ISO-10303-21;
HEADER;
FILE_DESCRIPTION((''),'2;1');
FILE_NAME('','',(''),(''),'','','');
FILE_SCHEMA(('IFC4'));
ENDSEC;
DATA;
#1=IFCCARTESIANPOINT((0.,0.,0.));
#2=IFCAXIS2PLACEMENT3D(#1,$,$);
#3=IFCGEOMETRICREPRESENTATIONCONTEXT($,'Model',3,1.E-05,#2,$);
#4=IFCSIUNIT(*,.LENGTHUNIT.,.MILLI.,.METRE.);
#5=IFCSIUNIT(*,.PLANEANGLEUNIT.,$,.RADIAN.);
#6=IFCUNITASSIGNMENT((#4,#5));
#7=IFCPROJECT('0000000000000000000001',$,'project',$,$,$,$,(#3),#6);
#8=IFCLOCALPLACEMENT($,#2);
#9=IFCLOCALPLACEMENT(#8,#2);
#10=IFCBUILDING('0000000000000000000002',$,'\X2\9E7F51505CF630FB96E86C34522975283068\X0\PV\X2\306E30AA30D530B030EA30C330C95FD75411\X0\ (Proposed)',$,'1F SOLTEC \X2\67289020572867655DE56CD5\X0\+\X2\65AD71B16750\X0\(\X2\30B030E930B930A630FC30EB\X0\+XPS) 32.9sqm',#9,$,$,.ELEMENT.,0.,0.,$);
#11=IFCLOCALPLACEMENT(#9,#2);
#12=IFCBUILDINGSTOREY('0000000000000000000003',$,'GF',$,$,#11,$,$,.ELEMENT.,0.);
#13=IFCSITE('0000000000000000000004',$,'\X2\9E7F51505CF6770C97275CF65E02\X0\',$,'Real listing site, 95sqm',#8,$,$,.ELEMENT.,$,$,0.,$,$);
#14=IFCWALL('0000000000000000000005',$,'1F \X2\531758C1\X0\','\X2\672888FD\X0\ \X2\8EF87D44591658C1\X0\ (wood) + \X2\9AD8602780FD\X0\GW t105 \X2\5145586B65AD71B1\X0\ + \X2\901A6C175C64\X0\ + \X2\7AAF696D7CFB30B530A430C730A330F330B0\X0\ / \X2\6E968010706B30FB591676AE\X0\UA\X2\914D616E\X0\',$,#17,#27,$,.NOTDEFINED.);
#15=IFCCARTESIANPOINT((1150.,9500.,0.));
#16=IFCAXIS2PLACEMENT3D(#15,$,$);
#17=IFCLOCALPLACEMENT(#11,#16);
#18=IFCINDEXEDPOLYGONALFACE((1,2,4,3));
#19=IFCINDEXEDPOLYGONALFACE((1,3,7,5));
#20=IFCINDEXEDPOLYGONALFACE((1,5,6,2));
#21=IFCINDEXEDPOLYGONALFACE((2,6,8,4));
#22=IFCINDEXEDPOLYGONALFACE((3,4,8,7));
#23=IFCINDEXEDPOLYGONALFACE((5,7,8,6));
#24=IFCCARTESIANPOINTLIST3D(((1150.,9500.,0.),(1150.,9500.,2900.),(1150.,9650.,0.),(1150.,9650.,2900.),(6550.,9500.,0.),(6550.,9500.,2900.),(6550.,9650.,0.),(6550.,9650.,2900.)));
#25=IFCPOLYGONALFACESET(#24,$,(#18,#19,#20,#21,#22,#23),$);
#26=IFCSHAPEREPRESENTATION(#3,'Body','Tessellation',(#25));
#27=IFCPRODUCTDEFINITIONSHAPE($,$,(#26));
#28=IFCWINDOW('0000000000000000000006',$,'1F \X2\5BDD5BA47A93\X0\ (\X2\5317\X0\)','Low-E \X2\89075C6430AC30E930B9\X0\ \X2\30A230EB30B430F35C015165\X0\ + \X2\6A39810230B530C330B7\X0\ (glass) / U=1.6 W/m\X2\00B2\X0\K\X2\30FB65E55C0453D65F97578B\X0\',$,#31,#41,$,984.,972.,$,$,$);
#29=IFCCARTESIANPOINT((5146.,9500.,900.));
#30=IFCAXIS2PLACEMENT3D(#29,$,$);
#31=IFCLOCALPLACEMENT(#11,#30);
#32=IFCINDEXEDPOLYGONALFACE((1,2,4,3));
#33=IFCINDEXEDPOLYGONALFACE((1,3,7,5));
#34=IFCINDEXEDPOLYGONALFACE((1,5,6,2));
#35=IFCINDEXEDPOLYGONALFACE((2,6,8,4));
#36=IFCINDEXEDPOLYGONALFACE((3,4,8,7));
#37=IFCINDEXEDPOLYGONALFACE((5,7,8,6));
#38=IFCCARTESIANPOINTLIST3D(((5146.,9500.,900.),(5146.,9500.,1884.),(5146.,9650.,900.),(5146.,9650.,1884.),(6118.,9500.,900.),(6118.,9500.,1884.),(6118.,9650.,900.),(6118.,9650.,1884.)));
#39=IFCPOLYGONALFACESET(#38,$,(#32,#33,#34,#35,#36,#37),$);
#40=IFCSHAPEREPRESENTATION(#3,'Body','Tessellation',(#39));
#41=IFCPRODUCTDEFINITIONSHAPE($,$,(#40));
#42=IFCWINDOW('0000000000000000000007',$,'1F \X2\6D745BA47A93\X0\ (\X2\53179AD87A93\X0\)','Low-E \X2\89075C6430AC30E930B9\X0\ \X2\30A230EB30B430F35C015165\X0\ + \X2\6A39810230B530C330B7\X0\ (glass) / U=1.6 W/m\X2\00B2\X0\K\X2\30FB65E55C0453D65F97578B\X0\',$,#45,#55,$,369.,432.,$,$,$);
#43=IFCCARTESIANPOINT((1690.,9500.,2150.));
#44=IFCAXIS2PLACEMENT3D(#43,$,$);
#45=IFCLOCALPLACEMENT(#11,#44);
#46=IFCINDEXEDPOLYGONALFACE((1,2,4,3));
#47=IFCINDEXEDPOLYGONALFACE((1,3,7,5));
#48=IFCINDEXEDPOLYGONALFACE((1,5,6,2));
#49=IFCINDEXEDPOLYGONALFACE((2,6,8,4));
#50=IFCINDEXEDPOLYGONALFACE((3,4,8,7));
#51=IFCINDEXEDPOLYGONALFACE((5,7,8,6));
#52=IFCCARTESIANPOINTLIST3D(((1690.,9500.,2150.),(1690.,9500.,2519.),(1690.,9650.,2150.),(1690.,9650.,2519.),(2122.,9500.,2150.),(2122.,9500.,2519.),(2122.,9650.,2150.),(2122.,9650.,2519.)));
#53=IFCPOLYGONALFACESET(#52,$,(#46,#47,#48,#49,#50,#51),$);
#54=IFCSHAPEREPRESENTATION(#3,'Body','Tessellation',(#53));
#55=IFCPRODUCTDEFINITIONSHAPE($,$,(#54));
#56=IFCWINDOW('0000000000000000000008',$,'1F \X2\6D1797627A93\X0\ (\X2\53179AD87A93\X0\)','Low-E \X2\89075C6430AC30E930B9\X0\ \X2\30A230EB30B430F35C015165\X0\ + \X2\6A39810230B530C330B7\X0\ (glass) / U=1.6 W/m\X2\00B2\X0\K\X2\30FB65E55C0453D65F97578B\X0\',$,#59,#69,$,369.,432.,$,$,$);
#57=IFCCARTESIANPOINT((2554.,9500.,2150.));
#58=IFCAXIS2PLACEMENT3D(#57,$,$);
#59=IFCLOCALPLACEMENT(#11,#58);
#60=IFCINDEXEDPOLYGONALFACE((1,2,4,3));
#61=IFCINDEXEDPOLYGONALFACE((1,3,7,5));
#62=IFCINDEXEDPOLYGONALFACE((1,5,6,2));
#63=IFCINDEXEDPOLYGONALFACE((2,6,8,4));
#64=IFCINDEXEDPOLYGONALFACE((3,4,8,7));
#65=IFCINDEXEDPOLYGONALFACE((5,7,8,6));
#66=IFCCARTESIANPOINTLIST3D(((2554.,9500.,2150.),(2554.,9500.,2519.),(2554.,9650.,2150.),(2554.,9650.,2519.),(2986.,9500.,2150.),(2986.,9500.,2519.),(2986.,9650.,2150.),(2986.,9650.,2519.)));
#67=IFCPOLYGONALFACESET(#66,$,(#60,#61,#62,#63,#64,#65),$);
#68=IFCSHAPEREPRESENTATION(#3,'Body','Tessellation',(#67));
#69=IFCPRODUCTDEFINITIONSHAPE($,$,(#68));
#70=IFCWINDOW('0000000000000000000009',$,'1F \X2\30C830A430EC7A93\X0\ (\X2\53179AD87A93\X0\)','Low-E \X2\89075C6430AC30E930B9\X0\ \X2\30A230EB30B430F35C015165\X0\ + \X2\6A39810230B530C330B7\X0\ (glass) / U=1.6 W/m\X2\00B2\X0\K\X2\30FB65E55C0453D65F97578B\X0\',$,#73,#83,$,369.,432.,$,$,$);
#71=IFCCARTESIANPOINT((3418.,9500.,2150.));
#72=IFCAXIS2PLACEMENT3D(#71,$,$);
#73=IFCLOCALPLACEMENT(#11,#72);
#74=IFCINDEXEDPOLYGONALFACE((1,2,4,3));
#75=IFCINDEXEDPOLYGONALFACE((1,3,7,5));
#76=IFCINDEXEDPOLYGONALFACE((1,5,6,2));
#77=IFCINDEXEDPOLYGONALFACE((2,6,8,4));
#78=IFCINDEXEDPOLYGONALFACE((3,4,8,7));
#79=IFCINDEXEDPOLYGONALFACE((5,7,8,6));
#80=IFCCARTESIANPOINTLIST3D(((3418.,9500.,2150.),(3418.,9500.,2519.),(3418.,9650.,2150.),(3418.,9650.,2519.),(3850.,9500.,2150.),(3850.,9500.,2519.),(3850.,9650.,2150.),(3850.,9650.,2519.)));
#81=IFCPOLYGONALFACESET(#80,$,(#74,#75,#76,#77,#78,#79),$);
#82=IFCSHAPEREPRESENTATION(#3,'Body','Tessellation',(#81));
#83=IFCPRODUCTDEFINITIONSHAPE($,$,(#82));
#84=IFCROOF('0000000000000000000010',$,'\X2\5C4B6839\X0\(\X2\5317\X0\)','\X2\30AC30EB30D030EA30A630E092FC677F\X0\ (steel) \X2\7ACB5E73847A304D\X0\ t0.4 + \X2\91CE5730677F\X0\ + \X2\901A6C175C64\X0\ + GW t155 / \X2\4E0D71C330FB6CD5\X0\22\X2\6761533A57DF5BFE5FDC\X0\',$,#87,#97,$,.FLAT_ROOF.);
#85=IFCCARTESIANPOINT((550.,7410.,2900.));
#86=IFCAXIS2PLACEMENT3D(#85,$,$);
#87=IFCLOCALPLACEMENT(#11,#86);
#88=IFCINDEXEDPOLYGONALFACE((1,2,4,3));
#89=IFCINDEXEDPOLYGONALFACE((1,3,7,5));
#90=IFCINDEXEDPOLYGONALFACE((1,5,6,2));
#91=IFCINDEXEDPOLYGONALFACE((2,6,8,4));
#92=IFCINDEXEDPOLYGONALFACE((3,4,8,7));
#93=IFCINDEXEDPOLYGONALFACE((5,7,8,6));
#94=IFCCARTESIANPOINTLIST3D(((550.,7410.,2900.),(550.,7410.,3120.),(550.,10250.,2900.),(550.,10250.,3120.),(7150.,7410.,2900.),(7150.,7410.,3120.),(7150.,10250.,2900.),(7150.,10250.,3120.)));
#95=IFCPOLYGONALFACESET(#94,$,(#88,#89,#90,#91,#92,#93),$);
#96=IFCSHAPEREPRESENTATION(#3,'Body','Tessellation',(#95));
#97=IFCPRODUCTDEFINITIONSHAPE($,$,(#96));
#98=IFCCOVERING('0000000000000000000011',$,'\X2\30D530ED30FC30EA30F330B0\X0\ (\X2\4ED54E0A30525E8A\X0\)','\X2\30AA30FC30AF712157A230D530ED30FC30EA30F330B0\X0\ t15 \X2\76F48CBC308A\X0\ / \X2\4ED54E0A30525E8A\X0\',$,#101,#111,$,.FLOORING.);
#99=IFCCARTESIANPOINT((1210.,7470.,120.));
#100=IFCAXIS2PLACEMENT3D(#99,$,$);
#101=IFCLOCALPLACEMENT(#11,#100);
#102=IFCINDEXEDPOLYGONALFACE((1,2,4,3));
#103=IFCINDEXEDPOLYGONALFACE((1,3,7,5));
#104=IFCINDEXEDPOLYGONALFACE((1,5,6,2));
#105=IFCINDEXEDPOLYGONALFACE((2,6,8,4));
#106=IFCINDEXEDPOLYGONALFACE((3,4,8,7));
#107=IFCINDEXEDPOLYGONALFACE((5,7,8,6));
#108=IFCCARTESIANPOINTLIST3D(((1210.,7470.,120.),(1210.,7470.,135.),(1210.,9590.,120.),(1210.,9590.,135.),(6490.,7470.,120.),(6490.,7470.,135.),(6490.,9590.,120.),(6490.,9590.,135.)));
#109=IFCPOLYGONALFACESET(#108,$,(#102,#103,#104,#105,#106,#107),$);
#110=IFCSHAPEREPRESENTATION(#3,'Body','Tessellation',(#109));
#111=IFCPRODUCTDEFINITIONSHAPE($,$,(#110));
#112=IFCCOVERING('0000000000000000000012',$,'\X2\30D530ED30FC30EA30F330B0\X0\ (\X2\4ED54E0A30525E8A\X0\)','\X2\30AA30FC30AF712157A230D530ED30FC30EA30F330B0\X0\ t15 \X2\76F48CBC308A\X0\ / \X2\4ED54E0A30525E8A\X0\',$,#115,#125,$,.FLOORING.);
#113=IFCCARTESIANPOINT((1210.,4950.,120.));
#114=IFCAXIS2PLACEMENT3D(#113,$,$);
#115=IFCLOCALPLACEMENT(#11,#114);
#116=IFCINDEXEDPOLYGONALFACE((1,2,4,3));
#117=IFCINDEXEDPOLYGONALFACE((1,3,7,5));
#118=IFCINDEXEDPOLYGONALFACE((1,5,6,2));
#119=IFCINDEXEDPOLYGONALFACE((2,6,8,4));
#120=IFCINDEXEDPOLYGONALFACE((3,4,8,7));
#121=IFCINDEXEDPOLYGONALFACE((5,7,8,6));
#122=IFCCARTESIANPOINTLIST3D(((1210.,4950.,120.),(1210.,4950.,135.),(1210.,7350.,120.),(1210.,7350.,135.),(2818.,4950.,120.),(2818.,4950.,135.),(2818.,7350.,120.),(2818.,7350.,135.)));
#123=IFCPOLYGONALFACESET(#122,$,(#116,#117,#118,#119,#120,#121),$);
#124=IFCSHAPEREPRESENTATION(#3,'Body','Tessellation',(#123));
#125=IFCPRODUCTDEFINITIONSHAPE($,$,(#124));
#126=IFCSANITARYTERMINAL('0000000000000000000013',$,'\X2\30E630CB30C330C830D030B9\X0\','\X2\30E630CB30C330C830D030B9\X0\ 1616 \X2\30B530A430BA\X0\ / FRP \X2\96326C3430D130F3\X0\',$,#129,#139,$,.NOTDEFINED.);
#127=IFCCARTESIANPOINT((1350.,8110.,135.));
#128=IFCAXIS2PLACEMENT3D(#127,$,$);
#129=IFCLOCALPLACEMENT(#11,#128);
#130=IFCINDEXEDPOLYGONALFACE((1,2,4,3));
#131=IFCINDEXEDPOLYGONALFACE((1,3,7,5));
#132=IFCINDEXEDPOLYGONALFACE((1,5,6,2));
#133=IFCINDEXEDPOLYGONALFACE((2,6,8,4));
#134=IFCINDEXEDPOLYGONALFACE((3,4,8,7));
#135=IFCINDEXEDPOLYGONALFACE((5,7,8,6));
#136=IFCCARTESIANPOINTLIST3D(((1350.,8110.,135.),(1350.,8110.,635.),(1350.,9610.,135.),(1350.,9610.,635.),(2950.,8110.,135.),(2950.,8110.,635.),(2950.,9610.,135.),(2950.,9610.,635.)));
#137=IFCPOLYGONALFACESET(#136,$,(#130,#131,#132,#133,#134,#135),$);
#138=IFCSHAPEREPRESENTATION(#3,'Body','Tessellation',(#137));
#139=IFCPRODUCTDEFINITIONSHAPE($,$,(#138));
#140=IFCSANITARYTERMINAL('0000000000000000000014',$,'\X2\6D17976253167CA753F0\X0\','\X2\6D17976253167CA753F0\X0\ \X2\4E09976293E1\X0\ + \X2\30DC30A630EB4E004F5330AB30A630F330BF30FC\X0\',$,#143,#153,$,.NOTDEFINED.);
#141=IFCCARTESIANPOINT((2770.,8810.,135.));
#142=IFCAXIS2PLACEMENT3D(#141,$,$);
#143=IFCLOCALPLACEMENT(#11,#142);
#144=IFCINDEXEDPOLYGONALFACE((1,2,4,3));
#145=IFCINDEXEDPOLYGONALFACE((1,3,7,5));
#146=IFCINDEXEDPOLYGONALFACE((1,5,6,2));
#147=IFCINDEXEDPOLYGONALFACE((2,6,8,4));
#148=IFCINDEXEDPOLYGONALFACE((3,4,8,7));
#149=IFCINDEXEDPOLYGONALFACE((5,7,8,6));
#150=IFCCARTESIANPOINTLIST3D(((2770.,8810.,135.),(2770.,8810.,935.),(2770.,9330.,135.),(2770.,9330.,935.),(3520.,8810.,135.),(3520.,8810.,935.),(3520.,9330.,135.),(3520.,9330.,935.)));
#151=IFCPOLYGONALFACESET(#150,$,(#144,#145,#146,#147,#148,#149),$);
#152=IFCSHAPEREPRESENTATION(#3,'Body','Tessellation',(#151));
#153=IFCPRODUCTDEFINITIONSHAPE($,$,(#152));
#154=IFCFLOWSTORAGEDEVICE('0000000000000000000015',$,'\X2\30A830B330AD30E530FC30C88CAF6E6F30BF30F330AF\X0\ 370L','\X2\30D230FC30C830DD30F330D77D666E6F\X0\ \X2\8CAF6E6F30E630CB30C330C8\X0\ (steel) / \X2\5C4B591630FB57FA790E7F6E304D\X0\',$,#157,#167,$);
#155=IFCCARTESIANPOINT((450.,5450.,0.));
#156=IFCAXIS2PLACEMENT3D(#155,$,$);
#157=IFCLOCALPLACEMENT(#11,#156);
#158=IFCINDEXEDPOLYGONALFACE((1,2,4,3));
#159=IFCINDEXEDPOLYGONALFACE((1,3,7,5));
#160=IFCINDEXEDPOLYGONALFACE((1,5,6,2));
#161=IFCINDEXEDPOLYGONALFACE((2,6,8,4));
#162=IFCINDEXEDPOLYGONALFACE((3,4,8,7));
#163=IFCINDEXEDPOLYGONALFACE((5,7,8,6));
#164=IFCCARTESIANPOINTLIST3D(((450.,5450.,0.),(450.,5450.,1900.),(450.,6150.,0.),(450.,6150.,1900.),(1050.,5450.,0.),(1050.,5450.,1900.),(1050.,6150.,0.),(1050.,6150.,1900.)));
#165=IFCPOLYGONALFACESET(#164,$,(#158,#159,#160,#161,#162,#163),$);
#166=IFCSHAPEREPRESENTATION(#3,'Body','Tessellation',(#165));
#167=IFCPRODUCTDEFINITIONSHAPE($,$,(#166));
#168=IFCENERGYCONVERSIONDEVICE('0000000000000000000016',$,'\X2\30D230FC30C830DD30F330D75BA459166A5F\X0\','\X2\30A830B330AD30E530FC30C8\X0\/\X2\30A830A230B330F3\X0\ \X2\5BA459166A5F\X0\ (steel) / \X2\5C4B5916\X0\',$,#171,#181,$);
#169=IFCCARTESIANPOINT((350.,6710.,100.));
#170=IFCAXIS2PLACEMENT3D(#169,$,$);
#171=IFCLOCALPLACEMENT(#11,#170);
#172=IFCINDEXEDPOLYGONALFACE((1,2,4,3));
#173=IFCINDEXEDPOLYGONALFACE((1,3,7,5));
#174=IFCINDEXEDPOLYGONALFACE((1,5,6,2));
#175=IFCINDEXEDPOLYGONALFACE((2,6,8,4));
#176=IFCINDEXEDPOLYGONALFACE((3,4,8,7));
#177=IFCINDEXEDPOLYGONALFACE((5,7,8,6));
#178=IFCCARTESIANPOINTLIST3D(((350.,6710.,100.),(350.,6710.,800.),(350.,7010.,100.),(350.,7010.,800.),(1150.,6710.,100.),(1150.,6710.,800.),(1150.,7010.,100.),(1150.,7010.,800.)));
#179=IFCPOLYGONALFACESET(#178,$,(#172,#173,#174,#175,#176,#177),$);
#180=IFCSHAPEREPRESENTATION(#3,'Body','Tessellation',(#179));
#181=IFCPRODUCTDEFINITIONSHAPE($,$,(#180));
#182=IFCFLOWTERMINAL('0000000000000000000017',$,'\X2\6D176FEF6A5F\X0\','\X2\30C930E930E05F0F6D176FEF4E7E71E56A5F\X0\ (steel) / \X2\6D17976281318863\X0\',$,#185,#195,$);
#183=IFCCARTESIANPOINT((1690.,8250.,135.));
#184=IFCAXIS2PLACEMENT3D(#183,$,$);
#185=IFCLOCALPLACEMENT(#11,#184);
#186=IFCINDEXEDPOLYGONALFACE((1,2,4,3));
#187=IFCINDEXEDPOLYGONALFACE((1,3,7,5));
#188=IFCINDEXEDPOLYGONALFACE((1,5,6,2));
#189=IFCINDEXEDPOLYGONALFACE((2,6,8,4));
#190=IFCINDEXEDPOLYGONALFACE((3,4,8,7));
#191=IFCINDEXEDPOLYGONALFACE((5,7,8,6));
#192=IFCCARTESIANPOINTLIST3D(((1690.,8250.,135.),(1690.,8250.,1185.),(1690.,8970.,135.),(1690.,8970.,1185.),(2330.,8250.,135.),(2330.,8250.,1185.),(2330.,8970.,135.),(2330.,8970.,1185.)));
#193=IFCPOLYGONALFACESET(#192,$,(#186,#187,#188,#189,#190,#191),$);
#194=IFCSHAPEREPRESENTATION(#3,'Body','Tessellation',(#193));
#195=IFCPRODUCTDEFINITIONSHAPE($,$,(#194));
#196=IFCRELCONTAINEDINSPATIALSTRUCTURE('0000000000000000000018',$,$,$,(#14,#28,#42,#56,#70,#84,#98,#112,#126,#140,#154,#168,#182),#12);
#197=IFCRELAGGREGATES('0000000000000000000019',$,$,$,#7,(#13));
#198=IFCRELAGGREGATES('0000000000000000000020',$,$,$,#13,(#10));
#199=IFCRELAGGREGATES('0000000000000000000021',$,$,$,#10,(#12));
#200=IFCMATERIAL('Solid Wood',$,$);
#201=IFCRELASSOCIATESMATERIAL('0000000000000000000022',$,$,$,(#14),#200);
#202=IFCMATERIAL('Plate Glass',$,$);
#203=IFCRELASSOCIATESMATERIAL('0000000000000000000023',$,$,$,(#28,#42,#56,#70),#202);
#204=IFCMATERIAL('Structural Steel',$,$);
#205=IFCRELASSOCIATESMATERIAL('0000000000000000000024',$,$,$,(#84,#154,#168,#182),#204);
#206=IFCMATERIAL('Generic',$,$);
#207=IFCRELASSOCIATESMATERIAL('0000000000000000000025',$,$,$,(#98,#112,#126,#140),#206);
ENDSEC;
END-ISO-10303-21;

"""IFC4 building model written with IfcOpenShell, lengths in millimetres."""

from ifc_helpers import new_model, si_unit, frame, frame_2d, origin, place, context, project, spatial, rectangle, extrude, material, element, fill, save


model = new_model("IFC4")

# Units and contexts
model_context = context("Model", 3, precision=1e-05, world=origin())
ifc_project = project(units=[si_unit("LENGTHUNIT", "METRE", prefix="MILLI"), si_unit("PLANEANGLEUNIT", "RADIAN")], contexts=[model_context])

# Site, building, storey
site_placement = place(None, origin())
site = spatial("IfcSite", under=ifc_project, at=site_placement, Name="鹿児島県霧島市", ObjectType="Real listing site, 95sqm", CompositionType="ELEMENT", RefElevation=0.0)
building_placement = place(site_placement, origin())
building = spatial("IfcBuilding", under=site, at=building_placement, Name="鹿児島・雨水利用とPVのオフグリッド志向 (Proposed)", ObjectType="1F SOLTEC 木造在来工法+断熱材(グラスウール+XPS) 32.9sqm", CompositionType="ELEMENT", ElevationOfRefHeight=0.0, ElevationOfTerrain=0.0)
storey_placement = place(building_placement, origin())
storey = spatial("IfcBuildingStorey", under=building, at=storey_placement, Name="GF", CompositionType="ELEMENT", Elevation=0.0)

# Shared definitions
ifc_material_1 = material(Name="Solid Wood")

# Wall, openings, windows
wall_1_placement = place(storey_placement, frame((1150.0, 9500.0, 0.0)))
wall_1 = element("IfcWall", 1, at=wall_1_placement, inside=storey, material=ifc_material_1, Name="1F 北壁", Description="木製 軸組外壁 (wood) + 高性能GW t105 充填断熱 + 通気層 + 窯業系サイディング / 準耐火・外皮UA配慮", PredefinedType="NOTDEFINED", context=model_context, shape_type="SweptSolid", body=[
    extrude(rectangle(XDim=5400.0, YDim=150.0, at=frame_2d((2700.0, 75.0))), frame((1150.0, 9500.0, 0.0)), (0.0, 0.0, 1.0), 2900.0),
])
opening_1_placement = place(storey_placement, frame((5146.0, 9500.0, 900.0)))
opening_1 = element("IfcOpeningElement", 2, at=opening_1_placement, cuts=wall_1, PredefinedType="NOTDEFINED", context=model_context, shape_type="SweptSolid", body=[
    extrude(rectangle(XDim=972.0, YDim=150.0, at=frame_2d((486.0, 75.0))), frame((5146.0, 9500.0, 900.0)), (0.0, 0.0, 1.0), 984.0),
])
opening_2_placement = place(storey_placement, frame((1690.0, 9500.0, 2150.0)))
opening_2 = element("IfcOpeningElement", 3, at=opening_2_placement, cuts=wall_1, PredefinedType="NOTDEFINED", context=model_context, shape_type="SweptSolid", body=[
    extrude(rectangle(XDim=432.0, YDim=150.0, at=frame_2d((216.0, 75.0))), frame((1690.0, 9500.0, 2150.0)), (0.0, 0.0, 1.0), 369.0),
])
opening_3_placement = place(storey_placement, frame((2554.0, 9500.0, 2150.0)))
opening_3 = element("IfcOpeningElement", 4, at=opening_3_placement, cuts=wall_1, PredefinedType="NOTDEFINED", context=model_context, shape_type="SweptSolid", body=[
    extrude(rectangle(XDim=432.0, YDim=150.0, at=frame_2d((216.0, 75.0))), frame((2554.0, 9500.0, 2150.0)), (0.0, 0.0, 1.0), 369.0),
])
opening_4_placement = place(storey_placement, frame((3418.0, 9500.0, 2150.0)))
opening_4 = element("IfcOpeningElement", 5, at=opening_4_placement, cuts=wall_1, PredefinedType="NOTDEFINED", context=model_context, shape_type="SweptSolid", body=[
    extrude(rectangle(XDim=432.0, YDim=150.0, at=frame_2d((216.0, 75.0))), frame((3418.0, 9500.0, 2150.0)), (0.0, 0.0, 1.0), 369.0),
])
ifc_material_2 = material(Name="Plate Glass")
window_1_placement = place(storey_placement, frame((5146.0, 9500.0, 900.0)))
window_1 = element("IfcWindow", 6, at=window_1_placement, inside=storey, material=ifc_material_2, Name="1F 寝室窓 (北)", Description="Low-E 複層ガラス アルゴン封入 + 樹脂サッシ (glass) / U=1.6 W/m²K・日射取得型", OverallHeight=984.0, OverallWidth=972.0, context=model_context, shape_type="SweptSolid", body=[
    extrude(rectangle(XDim=972.0, YDim=150.0, at=frame_2d((486.0, 75.0))), frame((5146.0, 9500.0, 900.0)), (0.0, 0.0, 1.0), 984.0),
])
fill(opening_1, window_1)
window_2_placement = place(storey_placement, frame((1690.0, 9500.0, 2150.0)))
window_2 = element("IfcWindow", 7, at=window_2_placement, inside=storey, material=ifc_material_2, Name="1F 浴室窓 (北高窓)", Description="Low-E 複層ガラス アルゴン封入 + 樹脂サッシ (glass) / U=1.6 W/m²K・日射取得型", OverallHeight=369.0, OverallWidth=432.0, context=model_context, shape_type="SweptSolid", body=[
    extrude(rectangle(XDim=432.0, YDim=150.0, at=frame_2d((216.0, 75.0))), frame((1690.0, 9500.0, 2150.0)), (0.0, 0.0, 1.0), 369.0),
])
fill(opening_2, window_2)
window_3_placement = place(storey_placement, frame((2554.0, 9500.0, 2150.0)))
window_3 = element("IfcWindow", 8, at=window_3_placement, inside=storey, material=ifc_material_2, Name="1F 洗面窓 (北高窓)", Description="Low-E 複層ガラス アルゴン封入 + 樹脂サッシ (glass) / U=1.6 W/m²K・日射取得型", OverallHeight=369.0, OverallWidth=432.0, context=model_context, shape_type="SweptSolid", body=[
    extrude(rectangle(XDim=432.0, YDim=150.0, at=frame_2d((216.0, 75.0))), frame((2554.0, 9500.0, 2150.0)), (0.0, 0.0, 1.0), 369.0),
])
fill(opening_3, window_3)
window_4_placement = place(storey_placement, frame((3418.0, 9500.0, 2150.0)))
window_4 = element("IfcWindow", 9, at=window_4_placement, inside=storey, material=ifc_material_2, Name="1F トイレ窓 (北高窓)", Description="Low-E 複層ガラス アルゴン封入 + 樹脂サッシ (glass) / U=1.6 W/m²K・日射取得型", OverallHeight=369.0, OverallWidth=432.0, context=model_context, shape_type="SweptSolid", body=[
    extrude(rectangle(XDim=432.0, YDim=150.0, at=frame_2d((216.0, 75.0))), frame((3418.0, 9500.0, 2150.0)), (0.0, 0.0, 1.0), 369.0),
])
fill(opening_4, window_4)

# Roof
ifc_material_3 = material(Name="Structural Steel")
roof_placement = place(storey_placement, frame((550.0, 7410.0, 2900.0)))
element("IfcRoof", 10, at=roof_placement, inside=storey, material=ifc_material_3, Name="屋根(北)", Description="ガルバリウム鋼板 (steel) 立平葺き t0.4 + 野地板 + 通気層 + GW t155 / 不燃・法22条区域対応", PredefinedType="FLAT_ROOF", context=model_context, shape_type="SweptSolid", body=[
    extrude(rectangle(XDim=6600.0, YDim=2840.0, at=frame_2d((3300.0, 1420.0))), frame((550.0, 7410.0, 2900.0)), (0.0, 0.0, 1.0), 220.0),
])

# Coverings
ifc_material_4 = material(Name="Generic")
covering_1_placement = place(storey_placement, frame((1210.0, 7470.0, 120.0)))
element("IfcCovering", 11, at=covering_1_placement, inside=storey, material=ifc_material_4, Name="フローリング (仕上げ床)", Description="オーク無垢フローリング t15 直貼り / 仕上げ床", PredefinedType="FLOORING", context=model_context, shape_type="SweptSolid", body=[
    extrude(rectangle(XDim=5280.0, YDim=2120.0, at=frame_2d((2640.0, 1060.0))), frame((1210.0, 7470.0, 120.0)), (0.0, 0.0, 1.0), 15.0),
])
covering_2_placement = place(storey_placement, frame((1210.0, 4950.0, 120.0)))
element("IfcCovering", 12, at=covering_2_placement, inside=storey, material=ifc_material_4, Name="フローリング (仕上げ床)", Description="オーク無垢フローリング t15 直貼り / 仕上げ床", PredefinedType="FLOORING", context=model_context, shape_type="SweptSolid", body=[
    extrude(rectangle(XDim=1608.0, YDim=2400.0, at=frame_2d((804.0, 1200.0))), frame((1210.0, 4950.0, 120.0)), (0.0, 0.0, 1.0), 15.0),
])

# Sanitary terminals
sanitary_terminal_1_placement = place(storey_placement, frame((1350.0, 8110.0, 135.0)))
element("IfcSanitaryTerminal", 13, at=sanitary_terminal_1_placement, inside=storey, material=ifc_material_4, Name="ユニットバス", Description="ユニットバス 1616 サイズ / FRP 防水パン", PredefinedType="NOTDEFINED", context=model_context, shape_type="SweptSolid", body=[
    extrude(rectangle(XDim=1600.0, YDim=1500.0, at=frame_2d((800.0, 750.0))), frame((1350.0, 8110.0, 135.0)), (0.0, 0.0, 1.0), 500.0),
])
sanitary_terminal_2_placement = place(storey_placement, frame((2770.0, 8810.0, 135.0)))
element("IfcSanitaryTerminal", 14, at=sanitary_terminal_2_placement, inside=storey, material=ifc_material_4, Name="洗面化粧台", Description="洗面化粧台 三面鏡 + ボウル一体カウンター", PredefinedType="NOTDEFINED", context=model_context, shape_type="SweptSolid", body=[
    extrude(rectangle(XDim=750.0, YDim=520.0, at=frame_2d((375.0, 260.0))), frame((2770.0, 8810.0, 135.0)), (0.0, 0.0, 1.0), 800.0),
])

# Flow storage device
flow_storage_device_placement = place(storey_placement, frame((450.0, 5450.0, 0.0)))
element("IfcFlowStorageDevice", 15, at=flow_storage_device_placement, inside=storey, material=ifc_material_3, Name="エコキュート貯湯タンク 370L", Description="ヒートポンプ給湯 貯湯ユニット (steel) / 屋外・基礎置き", context=model_context, shape_type="SweptSolid", body=[
    extrude(rectangle(XDim=600.0, YDim=700.0, at=frame_2d((300.0, 350.0))), frame((450.0, 5450.0, 0.0)), (0.0, 0.0, 1.0), 1900.0),
])

# Energy conversion device
energy_conversion_device_placement = place(storey_placement, frame((350.0, 6710.0, 100.0)))
element("IfcEnergyConversionDevice", 16, at=energy_conversion_device_placement, inside=storey, material=ifc_material_3, Name="ヒートポンプ室外機", Description="エコキュート/エアコン 室外機 (steel) / 屋外", context=model_context, shape_type="SweptSolid", body=[
    extrude(rectangle(XDim=800.0, YDim=300.0, at=frame_2d((400.0, 150.0))), frame((350.0, 6710.0, 100.0)), (0.0, 0.0, 1.0), 700.0),
])

# Flow terminal
flow_terminal_placement = place(storey_placement, frame((1690.0, 8250.0, 135.0)))
element("IfcFlowTerminal", 17, at=flow_terminal_placement, inside=storey, material=ifc_material_3, Name="洗濯機", Description="ドラム式洗濯乾燥機 (steel) / 洗面脱衣", context=model_context, shape_type="SweptSolid", body=[
    extrude(rectangle(XDim=640.0, YDim=720.0, at=frame_2d((320.0, 360.0))), frame((1690.0, 8250.0, 135.0)), (0.0, 0.0, 1.0), 1050.0),
])

save(model, "model.ifc")
